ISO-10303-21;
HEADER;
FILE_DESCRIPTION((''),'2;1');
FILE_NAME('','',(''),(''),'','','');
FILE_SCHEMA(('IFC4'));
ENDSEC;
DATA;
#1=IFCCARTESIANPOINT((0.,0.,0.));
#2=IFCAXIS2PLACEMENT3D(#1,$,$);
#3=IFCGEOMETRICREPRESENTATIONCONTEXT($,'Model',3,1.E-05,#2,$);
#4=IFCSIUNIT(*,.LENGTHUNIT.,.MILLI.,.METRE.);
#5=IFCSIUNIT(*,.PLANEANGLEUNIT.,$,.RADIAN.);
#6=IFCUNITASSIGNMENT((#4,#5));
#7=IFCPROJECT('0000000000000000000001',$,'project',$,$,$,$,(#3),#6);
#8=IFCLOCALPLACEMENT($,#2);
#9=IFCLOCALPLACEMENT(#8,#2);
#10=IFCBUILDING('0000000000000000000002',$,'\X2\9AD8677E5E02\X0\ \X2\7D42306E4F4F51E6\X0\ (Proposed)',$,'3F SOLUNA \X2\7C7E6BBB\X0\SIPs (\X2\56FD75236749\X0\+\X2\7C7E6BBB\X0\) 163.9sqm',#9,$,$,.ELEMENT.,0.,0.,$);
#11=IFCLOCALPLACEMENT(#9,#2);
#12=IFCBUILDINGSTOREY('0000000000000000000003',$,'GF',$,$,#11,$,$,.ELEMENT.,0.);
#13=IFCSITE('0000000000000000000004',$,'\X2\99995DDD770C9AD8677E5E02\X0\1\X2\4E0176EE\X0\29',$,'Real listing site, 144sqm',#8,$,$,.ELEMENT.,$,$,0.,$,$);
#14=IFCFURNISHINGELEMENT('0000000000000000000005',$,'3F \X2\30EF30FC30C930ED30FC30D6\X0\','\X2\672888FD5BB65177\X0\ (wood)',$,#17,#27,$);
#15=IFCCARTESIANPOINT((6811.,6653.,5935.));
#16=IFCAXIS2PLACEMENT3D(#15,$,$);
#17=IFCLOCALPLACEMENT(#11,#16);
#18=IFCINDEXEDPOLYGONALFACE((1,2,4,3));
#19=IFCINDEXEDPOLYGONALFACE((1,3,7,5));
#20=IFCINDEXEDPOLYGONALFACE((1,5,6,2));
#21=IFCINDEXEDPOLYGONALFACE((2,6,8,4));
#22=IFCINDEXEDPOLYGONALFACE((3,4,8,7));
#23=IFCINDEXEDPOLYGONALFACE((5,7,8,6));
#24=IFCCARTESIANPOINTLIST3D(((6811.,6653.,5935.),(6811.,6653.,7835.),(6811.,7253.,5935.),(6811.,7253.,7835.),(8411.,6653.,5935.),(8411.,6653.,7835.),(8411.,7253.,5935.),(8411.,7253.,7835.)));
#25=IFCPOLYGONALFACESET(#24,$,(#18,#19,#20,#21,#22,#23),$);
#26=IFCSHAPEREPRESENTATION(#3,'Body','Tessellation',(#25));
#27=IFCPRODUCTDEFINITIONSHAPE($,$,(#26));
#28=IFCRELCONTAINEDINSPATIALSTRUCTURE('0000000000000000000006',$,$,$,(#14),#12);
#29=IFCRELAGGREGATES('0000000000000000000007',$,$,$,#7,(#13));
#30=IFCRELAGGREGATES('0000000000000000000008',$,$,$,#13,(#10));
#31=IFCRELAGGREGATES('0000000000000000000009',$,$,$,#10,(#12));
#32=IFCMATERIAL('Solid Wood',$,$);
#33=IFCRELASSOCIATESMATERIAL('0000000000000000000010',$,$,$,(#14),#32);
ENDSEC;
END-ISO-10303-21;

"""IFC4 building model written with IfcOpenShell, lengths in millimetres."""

from ifc_helpers import new_model, si_unit, frame, frame_2d, origin, place, context, project, spatial, rectangle, extrude, material, element, save


model = new_model("IFC4")

# Units and contexts
model_context = context("Model", 3, precision=1e-05, world=origin())
ifc_project = project(units=[si_unit("LENGTHUNIT", "METRE", prefix="MILLI"), si_unit("PLANEANGLEUNIT", "RADIAN")], contexts=[model_context])

# Site, building, storey
site_placement = place(None, origin())
site = spatial("IfcSite", under=ifc_project, at=site_placement, Name="香川県高松市1丁目29", ObjectType="Real listing site, 144sqm", CompositionType="ELEMENT", RefElevation=0.0)
building_placement = place(site_placement, origin())
building = spatial("IfcBuilding", under=site, at=building_placement, Name="高松市 終の住処 (Proposed)", ObjectType="3F SOLUNA 籾殻SIPs (国産杉+籾殻) 163.9sqm", CompositionType="ELEMENT", ElevationOfRefHeight=0.0, ElevationOfTerrain=0.0)
storey_placement = place(building_placement, origin())
storey = spatial("IfcBuildingStorey", under=building, at=storey_placement, Name="GF", CompositionType="ELEMENT", Elevation=0.0)

# Shared definitions
ifc_material_1 = material(Name="Solid Wood")

# Furnishing element
furnishing_1_placement = place(storey_placement, frame((6811.0, 6653.0, 5935.0)))
element("IfcFurnishingElement", 1, at=furnishing_1_placement, inside=storey, material=ifc_material_1, Name="3F ワードローブ", Description="木製家具 (wood)", context=model_context, shape_type="SweptSolid", body=[
    extrude(rectangle(XDim=1600.0, YDim=600.0, at=frame_2d((800.0, 300.0))), frame((6811.0, 6653.0, 5935.0)), (0.0, 0.0, 1.0), 1900.0),
])

save(model, "model.ifc")
